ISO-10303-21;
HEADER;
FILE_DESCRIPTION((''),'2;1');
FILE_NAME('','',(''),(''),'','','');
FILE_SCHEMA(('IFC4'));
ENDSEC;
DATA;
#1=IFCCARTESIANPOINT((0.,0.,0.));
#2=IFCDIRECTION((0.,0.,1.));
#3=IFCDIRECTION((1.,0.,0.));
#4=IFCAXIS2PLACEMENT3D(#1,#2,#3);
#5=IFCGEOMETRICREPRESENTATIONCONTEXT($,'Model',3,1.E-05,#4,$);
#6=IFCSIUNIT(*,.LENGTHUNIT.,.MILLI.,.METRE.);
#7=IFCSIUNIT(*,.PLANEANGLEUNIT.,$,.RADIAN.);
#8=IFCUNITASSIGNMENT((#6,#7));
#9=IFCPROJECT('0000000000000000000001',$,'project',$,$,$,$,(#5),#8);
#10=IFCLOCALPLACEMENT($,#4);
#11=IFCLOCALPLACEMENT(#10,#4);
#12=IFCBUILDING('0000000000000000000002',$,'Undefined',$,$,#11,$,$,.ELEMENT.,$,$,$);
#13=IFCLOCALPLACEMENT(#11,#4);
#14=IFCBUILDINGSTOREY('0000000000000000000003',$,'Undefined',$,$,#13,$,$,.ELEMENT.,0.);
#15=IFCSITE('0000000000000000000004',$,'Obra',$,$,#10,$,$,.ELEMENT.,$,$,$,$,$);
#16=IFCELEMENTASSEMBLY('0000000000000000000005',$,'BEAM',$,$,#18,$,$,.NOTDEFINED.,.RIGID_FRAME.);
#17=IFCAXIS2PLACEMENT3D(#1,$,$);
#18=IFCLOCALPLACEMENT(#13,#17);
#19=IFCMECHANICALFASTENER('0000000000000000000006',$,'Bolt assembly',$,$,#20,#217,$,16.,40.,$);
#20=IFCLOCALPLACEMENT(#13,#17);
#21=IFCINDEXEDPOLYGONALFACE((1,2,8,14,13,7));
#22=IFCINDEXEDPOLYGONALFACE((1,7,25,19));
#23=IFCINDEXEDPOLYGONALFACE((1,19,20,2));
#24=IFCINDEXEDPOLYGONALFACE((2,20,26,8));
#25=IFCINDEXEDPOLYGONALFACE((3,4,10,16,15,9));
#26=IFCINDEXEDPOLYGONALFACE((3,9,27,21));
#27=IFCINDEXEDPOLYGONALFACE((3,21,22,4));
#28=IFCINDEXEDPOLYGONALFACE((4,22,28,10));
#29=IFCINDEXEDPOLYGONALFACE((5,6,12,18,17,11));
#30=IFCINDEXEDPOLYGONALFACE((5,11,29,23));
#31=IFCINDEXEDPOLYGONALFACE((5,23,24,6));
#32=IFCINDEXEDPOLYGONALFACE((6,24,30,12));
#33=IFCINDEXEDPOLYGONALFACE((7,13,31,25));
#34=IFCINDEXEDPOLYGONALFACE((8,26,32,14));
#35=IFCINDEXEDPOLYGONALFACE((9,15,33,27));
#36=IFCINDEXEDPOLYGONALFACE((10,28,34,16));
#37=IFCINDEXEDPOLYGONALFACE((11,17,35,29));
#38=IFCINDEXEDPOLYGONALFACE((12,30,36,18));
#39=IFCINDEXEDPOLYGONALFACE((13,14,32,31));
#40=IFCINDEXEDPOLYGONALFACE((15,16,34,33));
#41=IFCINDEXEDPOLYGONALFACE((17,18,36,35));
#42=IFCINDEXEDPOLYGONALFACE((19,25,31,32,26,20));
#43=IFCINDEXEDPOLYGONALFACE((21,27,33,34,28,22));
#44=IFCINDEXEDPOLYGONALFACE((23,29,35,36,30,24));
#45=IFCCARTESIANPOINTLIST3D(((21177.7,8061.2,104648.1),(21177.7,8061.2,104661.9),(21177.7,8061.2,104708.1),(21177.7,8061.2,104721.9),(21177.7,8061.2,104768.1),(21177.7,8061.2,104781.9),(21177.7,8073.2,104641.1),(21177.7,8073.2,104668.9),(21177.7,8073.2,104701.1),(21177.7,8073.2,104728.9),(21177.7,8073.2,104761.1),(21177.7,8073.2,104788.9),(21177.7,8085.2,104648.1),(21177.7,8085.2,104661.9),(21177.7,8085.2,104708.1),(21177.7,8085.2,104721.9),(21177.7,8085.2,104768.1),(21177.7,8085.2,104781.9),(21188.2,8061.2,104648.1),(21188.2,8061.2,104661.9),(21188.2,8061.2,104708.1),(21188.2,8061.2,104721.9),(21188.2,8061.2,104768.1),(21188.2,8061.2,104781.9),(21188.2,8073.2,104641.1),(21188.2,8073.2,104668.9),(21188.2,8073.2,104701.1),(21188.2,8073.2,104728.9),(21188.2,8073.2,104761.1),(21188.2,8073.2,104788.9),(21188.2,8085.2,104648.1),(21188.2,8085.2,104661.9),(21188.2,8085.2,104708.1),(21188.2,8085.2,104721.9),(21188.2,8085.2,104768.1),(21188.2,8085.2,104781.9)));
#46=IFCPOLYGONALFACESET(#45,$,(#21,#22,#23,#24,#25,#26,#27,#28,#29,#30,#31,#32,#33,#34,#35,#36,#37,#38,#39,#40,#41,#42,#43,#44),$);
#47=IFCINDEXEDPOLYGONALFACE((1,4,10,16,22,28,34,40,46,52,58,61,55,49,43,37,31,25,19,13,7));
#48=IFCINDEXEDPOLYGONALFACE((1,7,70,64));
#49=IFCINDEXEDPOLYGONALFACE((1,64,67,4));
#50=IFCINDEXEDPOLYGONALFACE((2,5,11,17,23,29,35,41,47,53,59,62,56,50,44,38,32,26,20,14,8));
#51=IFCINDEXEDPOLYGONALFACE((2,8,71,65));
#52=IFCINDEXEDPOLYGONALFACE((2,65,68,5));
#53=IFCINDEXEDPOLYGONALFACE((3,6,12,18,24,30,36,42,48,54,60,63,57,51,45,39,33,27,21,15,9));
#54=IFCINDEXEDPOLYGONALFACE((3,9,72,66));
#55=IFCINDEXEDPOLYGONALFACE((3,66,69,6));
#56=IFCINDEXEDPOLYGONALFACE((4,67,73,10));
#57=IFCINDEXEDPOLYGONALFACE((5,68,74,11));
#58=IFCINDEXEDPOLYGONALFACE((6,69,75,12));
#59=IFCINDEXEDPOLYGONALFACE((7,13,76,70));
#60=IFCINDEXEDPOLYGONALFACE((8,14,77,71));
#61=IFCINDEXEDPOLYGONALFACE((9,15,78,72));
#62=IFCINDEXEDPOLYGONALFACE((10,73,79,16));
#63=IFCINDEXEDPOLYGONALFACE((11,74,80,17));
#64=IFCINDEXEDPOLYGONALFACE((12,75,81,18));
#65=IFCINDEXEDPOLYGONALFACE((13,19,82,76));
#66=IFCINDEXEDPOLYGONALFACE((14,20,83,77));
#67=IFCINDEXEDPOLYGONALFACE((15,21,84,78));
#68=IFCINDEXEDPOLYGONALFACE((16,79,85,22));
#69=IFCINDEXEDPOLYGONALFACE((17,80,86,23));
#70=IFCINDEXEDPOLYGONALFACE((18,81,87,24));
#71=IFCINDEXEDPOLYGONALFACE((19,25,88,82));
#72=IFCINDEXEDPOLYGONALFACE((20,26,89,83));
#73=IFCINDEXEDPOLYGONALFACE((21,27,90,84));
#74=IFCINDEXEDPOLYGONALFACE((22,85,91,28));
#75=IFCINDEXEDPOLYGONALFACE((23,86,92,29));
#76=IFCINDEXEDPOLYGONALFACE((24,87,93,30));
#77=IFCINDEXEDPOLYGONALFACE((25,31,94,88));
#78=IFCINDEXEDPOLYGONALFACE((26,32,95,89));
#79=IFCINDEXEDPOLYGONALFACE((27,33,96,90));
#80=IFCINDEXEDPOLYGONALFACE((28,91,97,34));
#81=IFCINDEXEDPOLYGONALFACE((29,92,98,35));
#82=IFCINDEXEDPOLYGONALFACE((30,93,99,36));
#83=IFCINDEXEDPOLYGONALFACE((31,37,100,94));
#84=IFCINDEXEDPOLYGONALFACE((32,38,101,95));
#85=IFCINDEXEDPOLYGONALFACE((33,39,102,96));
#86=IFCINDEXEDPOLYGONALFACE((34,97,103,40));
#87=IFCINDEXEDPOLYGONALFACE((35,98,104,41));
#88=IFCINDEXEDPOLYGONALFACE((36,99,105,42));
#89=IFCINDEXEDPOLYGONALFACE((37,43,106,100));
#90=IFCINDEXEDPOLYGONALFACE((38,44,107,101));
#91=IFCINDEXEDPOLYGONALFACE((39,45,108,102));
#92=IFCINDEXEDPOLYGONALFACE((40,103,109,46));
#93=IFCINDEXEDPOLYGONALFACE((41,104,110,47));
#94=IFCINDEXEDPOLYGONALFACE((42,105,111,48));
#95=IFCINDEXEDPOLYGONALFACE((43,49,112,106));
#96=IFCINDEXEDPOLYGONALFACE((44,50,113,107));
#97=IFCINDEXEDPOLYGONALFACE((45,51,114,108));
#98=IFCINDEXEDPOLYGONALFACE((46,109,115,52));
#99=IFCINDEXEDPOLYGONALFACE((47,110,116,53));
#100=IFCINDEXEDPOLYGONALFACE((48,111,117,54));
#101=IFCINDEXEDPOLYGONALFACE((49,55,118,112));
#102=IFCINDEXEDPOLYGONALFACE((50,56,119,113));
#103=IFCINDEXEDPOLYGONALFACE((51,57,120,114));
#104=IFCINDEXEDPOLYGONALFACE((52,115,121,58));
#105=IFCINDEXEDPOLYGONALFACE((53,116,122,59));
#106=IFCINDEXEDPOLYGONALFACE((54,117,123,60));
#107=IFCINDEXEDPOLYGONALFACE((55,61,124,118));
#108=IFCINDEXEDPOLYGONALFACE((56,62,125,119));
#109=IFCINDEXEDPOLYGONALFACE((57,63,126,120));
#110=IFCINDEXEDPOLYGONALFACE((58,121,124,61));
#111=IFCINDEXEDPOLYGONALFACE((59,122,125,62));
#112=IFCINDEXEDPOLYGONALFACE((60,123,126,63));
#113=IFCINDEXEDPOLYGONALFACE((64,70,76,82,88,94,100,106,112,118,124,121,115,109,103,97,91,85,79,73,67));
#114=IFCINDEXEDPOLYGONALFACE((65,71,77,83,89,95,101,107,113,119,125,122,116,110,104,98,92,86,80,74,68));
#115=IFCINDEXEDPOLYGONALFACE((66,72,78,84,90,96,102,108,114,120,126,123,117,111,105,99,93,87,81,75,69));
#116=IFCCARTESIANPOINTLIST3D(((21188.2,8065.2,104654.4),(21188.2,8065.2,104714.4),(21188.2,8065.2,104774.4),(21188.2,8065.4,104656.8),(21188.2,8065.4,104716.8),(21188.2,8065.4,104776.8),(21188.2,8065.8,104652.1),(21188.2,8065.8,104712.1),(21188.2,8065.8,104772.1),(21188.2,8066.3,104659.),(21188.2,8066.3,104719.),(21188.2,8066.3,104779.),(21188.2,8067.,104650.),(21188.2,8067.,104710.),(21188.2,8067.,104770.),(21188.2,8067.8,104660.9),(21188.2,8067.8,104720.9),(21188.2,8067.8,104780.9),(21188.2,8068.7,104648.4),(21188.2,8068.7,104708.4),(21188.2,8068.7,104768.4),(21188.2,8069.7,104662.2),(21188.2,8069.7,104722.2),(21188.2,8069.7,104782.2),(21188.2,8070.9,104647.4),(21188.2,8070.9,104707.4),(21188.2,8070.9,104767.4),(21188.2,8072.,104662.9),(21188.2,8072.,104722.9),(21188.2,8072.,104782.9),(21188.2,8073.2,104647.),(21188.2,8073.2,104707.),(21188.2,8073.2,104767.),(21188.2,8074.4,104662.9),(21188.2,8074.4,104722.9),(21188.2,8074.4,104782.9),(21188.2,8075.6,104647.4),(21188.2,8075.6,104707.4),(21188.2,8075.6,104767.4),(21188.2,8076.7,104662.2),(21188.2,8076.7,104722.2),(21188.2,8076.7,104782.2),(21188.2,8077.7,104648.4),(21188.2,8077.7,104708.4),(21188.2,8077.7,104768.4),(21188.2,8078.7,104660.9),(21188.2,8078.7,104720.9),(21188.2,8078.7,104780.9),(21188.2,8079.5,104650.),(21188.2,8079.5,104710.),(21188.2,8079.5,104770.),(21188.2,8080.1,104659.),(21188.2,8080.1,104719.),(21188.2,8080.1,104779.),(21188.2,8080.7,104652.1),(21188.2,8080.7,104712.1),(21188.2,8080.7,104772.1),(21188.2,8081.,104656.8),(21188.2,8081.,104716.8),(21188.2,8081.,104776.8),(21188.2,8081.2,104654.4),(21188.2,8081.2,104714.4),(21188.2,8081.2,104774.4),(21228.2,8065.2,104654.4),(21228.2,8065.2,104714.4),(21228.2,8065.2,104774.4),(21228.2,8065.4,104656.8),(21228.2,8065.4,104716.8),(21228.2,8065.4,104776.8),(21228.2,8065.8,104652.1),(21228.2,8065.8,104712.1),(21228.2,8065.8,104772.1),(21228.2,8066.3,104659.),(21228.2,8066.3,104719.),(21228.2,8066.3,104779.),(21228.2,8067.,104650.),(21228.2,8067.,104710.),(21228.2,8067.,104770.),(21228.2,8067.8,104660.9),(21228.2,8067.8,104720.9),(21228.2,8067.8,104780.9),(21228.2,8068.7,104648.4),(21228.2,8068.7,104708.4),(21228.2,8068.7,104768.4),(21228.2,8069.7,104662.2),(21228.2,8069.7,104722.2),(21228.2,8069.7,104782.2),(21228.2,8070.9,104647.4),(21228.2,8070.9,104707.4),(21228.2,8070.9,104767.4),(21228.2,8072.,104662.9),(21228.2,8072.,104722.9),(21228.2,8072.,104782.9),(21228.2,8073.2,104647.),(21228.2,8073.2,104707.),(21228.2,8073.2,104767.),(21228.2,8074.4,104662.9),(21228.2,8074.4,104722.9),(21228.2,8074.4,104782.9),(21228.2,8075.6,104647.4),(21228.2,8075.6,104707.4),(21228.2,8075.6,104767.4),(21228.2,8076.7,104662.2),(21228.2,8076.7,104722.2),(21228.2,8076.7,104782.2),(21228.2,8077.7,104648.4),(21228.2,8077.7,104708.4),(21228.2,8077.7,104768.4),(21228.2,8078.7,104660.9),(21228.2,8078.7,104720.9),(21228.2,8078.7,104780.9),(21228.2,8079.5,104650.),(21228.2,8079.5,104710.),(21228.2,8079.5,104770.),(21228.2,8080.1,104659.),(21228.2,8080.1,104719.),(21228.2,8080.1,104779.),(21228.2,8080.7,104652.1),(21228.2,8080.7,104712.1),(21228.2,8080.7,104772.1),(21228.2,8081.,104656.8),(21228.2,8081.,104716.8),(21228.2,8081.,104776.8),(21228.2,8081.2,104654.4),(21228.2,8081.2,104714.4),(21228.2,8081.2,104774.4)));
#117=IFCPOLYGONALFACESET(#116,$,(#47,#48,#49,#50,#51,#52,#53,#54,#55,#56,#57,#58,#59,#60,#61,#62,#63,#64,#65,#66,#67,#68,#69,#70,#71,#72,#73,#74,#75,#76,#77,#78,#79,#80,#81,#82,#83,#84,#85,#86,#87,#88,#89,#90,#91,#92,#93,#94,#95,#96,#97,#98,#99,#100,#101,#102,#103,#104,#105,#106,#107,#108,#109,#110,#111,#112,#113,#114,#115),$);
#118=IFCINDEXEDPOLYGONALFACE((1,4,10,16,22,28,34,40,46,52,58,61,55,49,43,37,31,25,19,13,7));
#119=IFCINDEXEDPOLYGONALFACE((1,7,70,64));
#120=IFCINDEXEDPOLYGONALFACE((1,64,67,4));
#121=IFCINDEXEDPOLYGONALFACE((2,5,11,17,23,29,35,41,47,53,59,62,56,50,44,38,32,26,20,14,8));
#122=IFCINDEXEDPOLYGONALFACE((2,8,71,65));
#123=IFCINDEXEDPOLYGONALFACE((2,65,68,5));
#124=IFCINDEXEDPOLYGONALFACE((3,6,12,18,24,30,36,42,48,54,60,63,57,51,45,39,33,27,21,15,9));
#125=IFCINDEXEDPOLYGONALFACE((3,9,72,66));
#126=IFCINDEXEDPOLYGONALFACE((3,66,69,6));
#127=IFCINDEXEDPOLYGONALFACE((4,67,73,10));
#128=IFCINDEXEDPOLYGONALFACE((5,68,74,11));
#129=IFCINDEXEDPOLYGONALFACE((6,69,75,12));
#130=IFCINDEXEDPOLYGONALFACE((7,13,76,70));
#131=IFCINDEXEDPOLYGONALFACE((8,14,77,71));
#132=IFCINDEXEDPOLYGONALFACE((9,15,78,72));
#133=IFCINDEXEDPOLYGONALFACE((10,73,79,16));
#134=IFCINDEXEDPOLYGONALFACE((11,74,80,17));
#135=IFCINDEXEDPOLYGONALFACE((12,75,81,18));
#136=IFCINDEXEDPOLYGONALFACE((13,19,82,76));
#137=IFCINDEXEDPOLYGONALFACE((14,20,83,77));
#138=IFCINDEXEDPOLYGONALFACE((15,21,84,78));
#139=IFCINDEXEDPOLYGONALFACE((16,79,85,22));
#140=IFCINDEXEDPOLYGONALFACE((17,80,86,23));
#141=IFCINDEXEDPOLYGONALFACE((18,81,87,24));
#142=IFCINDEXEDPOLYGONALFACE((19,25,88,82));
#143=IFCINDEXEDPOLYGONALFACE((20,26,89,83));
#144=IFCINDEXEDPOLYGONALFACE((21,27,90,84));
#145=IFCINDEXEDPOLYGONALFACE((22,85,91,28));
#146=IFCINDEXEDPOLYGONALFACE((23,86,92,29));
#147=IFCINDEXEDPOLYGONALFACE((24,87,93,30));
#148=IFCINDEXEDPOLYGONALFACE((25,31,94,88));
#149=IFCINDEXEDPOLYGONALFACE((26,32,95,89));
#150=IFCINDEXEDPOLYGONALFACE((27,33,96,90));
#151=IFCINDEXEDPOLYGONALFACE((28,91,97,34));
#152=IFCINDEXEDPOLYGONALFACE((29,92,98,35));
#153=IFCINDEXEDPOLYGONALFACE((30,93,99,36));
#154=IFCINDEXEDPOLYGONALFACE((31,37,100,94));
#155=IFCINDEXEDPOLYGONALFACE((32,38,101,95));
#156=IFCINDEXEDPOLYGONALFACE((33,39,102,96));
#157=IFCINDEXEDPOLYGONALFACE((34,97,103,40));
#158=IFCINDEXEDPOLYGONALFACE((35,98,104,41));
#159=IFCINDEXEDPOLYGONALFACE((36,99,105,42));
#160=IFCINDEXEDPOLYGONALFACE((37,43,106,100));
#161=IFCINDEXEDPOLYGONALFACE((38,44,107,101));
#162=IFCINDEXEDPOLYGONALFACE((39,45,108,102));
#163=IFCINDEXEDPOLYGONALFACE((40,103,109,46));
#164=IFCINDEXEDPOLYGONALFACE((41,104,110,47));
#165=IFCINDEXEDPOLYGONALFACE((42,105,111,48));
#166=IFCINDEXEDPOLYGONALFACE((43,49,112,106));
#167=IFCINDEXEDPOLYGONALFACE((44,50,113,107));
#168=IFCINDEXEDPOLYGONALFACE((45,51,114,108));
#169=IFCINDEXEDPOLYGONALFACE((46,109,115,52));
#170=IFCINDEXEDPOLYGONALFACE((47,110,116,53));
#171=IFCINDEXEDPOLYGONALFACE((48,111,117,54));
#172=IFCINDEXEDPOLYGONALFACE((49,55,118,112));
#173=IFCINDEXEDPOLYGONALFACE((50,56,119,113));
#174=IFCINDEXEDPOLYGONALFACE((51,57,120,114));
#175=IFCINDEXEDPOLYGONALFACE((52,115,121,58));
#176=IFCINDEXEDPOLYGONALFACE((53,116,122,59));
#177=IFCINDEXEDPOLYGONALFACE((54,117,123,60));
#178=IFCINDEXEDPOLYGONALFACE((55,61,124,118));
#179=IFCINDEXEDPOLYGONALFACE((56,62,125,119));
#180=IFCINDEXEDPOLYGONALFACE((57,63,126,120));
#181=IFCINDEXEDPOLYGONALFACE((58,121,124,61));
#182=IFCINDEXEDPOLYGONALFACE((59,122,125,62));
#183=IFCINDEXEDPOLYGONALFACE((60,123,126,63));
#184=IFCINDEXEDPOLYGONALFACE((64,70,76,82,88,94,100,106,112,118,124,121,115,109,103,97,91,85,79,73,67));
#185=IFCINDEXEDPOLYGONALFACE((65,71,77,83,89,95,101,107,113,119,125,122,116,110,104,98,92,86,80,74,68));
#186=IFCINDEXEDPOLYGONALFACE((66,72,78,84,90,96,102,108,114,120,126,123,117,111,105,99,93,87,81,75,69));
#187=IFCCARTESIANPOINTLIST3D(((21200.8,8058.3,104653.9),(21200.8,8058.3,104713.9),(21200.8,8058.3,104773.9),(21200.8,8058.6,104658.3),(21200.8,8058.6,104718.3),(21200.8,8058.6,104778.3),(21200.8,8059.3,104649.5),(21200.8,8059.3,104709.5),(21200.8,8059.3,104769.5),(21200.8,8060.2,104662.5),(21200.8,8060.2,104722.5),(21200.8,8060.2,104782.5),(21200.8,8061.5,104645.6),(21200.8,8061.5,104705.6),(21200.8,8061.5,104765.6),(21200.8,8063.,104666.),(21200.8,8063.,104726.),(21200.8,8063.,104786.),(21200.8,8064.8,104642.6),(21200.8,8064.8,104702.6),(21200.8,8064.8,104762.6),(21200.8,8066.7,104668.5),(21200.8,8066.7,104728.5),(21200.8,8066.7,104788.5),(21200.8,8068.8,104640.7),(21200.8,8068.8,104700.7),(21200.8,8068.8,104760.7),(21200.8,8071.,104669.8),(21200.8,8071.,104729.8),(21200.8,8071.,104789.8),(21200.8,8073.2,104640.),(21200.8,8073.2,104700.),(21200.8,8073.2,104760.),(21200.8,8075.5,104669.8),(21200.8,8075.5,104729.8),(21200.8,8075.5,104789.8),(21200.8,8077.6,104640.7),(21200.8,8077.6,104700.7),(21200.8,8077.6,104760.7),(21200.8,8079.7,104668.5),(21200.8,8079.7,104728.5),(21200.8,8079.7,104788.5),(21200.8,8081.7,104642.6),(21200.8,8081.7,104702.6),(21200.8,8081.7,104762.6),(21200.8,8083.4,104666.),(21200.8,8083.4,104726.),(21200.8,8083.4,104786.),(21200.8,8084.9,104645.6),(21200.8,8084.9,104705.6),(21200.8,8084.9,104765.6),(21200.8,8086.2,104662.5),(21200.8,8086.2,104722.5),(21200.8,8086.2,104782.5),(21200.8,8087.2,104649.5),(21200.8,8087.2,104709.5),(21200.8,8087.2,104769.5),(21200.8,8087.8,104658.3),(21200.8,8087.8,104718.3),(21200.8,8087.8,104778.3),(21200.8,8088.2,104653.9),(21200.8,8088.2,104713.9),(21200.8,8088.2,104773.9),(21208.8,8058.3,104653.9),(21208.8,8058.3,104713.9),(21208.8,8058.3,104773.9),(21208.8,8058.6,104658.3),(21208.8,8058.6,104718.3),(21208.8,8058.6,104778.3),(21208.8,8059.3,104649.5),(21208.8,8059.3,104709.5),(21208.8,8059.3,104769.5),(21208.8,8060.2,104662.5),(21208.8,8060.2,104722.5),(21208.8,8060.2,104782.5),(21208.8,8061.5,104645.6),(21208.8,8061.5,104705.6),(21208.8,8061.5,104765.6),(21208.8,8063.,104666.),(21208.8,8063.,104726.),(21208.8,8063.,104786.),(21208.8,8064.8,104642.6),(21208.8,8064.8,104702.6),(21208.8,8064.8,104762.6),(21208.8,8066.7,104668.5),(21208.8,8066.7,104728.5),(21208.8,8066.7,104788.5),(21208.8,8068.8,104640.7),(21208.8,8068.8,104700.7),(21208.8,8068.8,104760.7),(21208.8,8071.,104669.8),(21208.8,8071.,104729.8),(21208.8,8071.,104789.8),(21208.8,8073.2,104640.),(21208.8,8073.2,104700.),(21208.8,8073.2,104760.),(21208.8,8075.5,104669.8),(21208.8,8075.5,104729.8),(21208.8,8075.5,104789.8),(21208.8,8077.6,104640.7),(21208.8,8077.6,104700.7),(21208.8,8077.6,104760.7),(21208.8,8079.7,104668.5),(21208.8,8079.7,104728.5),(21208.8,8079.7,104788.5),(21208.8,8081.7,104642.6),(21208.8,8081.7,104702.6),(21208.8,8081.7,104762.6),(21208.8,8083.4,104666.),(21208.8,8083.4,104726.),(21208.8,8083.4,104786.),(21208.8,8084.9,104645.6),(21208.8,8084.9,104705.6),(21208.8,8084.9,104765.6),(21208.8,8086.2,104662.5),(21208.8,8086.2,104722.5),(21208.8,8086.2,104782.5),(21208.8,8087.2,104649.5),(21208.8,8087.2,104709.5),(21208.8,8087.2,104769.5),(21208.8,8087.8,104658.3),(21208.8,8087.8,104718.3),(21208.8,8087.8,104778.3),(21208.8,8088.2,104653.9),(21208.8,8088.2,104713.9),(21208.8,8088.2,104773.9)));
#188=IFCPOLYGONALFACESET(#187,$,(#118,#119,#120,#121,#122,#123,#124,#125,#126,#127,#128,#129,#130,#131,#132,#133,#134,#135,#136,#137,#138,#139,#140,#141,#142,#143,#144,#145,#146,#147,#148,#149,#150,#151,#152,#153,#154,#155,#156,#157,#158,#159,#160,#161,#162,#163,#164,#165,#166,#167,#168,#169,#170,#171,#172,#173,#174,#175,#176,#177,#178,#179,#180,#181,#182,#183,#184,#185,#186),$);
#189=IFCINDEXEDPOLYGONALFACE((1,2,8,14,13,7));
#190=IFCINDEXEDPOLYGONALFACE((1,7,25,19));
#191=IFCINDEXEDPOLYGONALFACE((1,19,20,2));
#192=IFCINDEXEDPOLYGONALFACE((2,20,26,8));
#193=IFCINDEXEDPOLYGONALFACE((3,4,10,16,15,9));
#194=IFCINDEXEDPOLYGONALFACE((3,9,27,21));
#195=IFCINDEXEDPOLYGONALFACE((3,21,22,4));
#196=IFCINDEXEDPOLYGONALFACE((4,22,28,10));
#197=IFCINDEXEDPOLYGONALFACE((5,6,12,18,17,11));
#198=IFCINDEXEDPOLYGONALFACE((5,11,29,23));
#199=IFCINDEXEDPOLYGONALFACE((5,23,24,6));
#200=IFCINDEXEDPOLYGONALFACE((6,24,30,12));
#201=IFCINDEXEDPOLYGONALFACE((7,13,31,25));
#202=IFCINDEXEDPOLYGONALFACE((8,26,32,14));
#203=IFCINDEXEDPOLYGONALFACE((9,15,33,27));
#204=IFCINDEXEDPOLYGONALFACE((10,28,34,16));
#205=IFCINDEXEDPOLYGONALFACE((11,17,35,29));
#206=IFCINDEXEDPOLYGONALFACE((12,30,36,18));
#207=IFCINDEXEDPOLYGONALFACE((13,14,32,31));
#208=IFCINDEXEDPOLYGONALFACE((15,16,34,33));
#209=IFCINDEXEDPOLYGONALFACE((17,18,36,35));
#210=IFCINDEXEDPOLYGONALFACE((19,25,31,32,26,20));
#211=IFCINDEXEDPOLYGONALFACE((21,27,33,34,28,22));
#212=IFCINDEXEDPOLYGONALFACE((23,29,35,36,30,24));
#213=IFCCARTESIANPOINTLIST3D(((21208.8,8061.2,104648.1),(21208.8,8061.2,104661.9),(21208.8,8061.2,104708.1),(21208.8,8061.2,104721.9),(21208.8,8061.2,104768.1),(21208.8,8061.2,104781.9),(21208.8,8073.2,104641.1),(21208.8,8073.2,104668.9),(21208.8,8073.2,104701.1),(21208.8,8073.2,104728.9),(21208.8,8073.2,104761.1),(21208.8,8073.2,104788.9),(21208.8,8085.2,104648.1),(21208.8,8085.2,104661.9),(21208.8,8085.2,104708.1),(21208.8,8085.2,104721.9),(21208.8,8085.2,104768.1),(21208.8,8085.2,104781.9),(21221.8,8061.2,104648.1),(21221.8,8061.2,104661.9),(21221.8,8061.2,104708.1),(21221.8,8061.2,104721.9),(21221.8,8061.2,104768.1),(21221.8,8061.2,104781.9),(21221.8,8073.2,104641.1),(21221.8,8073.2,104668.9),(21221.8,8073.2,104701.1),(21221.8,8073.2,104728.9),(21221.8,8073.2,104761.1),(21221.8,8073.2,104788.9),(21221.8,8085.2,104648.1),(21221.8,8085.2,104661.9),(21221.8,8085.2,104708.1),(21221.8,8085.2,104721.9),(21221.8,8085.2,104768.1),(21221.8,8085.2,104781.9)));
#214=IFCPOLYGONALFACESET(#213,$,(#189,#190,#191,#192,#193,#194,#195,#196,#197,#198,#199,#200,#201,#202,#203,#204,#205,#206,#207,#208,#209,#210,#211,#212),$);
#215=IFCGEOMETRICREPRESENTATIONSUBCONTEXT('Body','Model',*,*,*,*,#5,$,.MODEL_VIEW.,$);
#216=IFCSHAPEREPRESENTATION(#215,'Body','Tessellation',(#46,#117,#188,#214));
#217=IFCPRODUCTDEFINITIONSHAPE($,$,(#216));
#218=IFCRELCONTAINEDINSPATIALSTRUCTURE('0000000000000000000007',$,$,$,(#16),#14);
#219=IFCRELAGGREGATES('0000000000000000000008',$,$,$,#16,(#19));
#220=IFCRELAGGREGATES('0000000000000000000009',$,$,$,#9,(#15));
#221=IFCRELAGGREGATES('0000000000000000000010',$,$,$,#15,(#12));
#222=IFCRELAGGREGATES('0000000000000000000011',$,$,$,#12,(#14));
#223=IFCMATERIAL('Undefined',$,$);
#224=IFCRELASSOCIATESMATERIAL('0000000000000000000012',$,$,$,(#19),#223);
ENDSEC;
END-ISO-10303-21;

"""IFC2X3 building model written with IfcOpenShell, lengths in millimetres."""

from ifc_helpers import new_model, si_unit, frame, origin_with_axes, origin_2d_with_axis, place, context, subcontext, project, spatial, polyline, circle, outline, extrude, source, transform, mapped, material, element, aggregate, save


model = new_model("IFC2X3")

# Units and contexts
model_context = context("Model", 3, precision=1e-05, world=origin_with_axes())
body_context = subcontext(model_context, "Body", "Model", "MODEL_VIEW")
ifc_project = project(units=[si_unit("LENGTHUNIT", "METRE", prefix="MILLI"), si_unit("PLANEANGLEUNIT", "RADIAN")], contexts=[model_context])

# Site, building, storey
site_placement = place(None, origin_with_axes())
site = spatial("IfcSite", under=ifc_project, at=site_placement, Name="Obra", CompositionType="ELEMENT")
building_placement = place(site_placement, origin_with_axes())
building = spatial("IfcBuilding", under=site, at=building_placement, Name="Undefined", CompositionType="ELEMENT")
storey_placement = place(building_placement, origin_with_axes())
storey = spatial("IfcBuildingStorey", under=building, at=storey_placement, Name="Undefined", CompositionType="ELEMENT", Elevation=0.0)

# Shared definitions
ifc_material_1 = material(Name="Undefined")

# Element assembly, mechanical fastener
shared_shape_1 = source(origin_with_axes(), body_context, "Body", "SweptSolid", [
    extrude(outline(polyline([(13.9, 0.0), (6.9, 12.0), (-6.9, 12.0), (-13.9, 0.0), (-6.9, -12.0), (6.9, -12.0), (13.9, 0.0)])), frame((0.0, -19.9, 0.0), z_axis=(0.0, 1.0, 0.0), x_axis=(1.0, 0.0, 0.0)), (0.0, 0.0, 1.0), 10.6),
    extrude(circle(Radius=8.0, at=origin_2d_with_axis()), frame((0.0, -9.3, 0.0), z_axis=(0.0, 1.0, 0.0), x_axis=(1.0, 0.0, 0.0)), (0.0, 0.0, 1.0), 40.0),
    extrude(circle(Radius=15.0, at=origin_2d_with_axis()), frame((0.0, 3.3, 0.0), z_axis=(0.0, 1.0, 0.0), x_axis=(1.0, 0.0, 0.0)), (0.0, 0.0, 1.0), 8.0),
    extrude(outline(polyline([(13.9, 0.0), (6.9, 12.0), (-6.9, 12.0), (-13.9, 0.0), (-6.9, -12.0), (6.9, -12.0), (13.9, 0.0)])), frame((0.0, 11.3, 0.0), z_axis=(0.0, 1.0, 0.0), x_axis=(1.0, 0.0, 0.0)), (0.0, 0.0, 1.0), 13.0),
])
assembly_1_placement = place(storey_placement, origin_with_axes())
assembly_1 = element("IfcElementAssembly", 1, at=assembly_1_placement, inside=storey, Name="BEAM", AssemblyPlace="NOTDEFINED", PredefinedType="RIGID_FRAME")
mechanical_fastener_1_placement = place(assembly_1_placement, frame((21197.5, 8108.2, 104850.0), z_axis=(0.0, -1.0, 0.0), x_axis=(0.0, 0.0, -1.0)))
mechanical_fastener_1 = element("IfcMechanicalFastener", 2, at=mechanical_fastener_1_placement, material=ifc_material_1, Name="Bolt assembly", NominalDiameter=16.0, NominalLength=40.0, context=body_context, shape_type="MappedRepresentation", body=[
    mapped(shared_shape_1, transform((75.0, 0.0, 35.0))),
    mapped(shared_shape_1, transform((135.0, 0.0, 35.0))),
    mapped(shared_shape_1, transform((195.0, 0.0, 35.0))),
])

aggregate(assembly_1, [mechanical_fastener_1])

save(model, "model.ifc")
